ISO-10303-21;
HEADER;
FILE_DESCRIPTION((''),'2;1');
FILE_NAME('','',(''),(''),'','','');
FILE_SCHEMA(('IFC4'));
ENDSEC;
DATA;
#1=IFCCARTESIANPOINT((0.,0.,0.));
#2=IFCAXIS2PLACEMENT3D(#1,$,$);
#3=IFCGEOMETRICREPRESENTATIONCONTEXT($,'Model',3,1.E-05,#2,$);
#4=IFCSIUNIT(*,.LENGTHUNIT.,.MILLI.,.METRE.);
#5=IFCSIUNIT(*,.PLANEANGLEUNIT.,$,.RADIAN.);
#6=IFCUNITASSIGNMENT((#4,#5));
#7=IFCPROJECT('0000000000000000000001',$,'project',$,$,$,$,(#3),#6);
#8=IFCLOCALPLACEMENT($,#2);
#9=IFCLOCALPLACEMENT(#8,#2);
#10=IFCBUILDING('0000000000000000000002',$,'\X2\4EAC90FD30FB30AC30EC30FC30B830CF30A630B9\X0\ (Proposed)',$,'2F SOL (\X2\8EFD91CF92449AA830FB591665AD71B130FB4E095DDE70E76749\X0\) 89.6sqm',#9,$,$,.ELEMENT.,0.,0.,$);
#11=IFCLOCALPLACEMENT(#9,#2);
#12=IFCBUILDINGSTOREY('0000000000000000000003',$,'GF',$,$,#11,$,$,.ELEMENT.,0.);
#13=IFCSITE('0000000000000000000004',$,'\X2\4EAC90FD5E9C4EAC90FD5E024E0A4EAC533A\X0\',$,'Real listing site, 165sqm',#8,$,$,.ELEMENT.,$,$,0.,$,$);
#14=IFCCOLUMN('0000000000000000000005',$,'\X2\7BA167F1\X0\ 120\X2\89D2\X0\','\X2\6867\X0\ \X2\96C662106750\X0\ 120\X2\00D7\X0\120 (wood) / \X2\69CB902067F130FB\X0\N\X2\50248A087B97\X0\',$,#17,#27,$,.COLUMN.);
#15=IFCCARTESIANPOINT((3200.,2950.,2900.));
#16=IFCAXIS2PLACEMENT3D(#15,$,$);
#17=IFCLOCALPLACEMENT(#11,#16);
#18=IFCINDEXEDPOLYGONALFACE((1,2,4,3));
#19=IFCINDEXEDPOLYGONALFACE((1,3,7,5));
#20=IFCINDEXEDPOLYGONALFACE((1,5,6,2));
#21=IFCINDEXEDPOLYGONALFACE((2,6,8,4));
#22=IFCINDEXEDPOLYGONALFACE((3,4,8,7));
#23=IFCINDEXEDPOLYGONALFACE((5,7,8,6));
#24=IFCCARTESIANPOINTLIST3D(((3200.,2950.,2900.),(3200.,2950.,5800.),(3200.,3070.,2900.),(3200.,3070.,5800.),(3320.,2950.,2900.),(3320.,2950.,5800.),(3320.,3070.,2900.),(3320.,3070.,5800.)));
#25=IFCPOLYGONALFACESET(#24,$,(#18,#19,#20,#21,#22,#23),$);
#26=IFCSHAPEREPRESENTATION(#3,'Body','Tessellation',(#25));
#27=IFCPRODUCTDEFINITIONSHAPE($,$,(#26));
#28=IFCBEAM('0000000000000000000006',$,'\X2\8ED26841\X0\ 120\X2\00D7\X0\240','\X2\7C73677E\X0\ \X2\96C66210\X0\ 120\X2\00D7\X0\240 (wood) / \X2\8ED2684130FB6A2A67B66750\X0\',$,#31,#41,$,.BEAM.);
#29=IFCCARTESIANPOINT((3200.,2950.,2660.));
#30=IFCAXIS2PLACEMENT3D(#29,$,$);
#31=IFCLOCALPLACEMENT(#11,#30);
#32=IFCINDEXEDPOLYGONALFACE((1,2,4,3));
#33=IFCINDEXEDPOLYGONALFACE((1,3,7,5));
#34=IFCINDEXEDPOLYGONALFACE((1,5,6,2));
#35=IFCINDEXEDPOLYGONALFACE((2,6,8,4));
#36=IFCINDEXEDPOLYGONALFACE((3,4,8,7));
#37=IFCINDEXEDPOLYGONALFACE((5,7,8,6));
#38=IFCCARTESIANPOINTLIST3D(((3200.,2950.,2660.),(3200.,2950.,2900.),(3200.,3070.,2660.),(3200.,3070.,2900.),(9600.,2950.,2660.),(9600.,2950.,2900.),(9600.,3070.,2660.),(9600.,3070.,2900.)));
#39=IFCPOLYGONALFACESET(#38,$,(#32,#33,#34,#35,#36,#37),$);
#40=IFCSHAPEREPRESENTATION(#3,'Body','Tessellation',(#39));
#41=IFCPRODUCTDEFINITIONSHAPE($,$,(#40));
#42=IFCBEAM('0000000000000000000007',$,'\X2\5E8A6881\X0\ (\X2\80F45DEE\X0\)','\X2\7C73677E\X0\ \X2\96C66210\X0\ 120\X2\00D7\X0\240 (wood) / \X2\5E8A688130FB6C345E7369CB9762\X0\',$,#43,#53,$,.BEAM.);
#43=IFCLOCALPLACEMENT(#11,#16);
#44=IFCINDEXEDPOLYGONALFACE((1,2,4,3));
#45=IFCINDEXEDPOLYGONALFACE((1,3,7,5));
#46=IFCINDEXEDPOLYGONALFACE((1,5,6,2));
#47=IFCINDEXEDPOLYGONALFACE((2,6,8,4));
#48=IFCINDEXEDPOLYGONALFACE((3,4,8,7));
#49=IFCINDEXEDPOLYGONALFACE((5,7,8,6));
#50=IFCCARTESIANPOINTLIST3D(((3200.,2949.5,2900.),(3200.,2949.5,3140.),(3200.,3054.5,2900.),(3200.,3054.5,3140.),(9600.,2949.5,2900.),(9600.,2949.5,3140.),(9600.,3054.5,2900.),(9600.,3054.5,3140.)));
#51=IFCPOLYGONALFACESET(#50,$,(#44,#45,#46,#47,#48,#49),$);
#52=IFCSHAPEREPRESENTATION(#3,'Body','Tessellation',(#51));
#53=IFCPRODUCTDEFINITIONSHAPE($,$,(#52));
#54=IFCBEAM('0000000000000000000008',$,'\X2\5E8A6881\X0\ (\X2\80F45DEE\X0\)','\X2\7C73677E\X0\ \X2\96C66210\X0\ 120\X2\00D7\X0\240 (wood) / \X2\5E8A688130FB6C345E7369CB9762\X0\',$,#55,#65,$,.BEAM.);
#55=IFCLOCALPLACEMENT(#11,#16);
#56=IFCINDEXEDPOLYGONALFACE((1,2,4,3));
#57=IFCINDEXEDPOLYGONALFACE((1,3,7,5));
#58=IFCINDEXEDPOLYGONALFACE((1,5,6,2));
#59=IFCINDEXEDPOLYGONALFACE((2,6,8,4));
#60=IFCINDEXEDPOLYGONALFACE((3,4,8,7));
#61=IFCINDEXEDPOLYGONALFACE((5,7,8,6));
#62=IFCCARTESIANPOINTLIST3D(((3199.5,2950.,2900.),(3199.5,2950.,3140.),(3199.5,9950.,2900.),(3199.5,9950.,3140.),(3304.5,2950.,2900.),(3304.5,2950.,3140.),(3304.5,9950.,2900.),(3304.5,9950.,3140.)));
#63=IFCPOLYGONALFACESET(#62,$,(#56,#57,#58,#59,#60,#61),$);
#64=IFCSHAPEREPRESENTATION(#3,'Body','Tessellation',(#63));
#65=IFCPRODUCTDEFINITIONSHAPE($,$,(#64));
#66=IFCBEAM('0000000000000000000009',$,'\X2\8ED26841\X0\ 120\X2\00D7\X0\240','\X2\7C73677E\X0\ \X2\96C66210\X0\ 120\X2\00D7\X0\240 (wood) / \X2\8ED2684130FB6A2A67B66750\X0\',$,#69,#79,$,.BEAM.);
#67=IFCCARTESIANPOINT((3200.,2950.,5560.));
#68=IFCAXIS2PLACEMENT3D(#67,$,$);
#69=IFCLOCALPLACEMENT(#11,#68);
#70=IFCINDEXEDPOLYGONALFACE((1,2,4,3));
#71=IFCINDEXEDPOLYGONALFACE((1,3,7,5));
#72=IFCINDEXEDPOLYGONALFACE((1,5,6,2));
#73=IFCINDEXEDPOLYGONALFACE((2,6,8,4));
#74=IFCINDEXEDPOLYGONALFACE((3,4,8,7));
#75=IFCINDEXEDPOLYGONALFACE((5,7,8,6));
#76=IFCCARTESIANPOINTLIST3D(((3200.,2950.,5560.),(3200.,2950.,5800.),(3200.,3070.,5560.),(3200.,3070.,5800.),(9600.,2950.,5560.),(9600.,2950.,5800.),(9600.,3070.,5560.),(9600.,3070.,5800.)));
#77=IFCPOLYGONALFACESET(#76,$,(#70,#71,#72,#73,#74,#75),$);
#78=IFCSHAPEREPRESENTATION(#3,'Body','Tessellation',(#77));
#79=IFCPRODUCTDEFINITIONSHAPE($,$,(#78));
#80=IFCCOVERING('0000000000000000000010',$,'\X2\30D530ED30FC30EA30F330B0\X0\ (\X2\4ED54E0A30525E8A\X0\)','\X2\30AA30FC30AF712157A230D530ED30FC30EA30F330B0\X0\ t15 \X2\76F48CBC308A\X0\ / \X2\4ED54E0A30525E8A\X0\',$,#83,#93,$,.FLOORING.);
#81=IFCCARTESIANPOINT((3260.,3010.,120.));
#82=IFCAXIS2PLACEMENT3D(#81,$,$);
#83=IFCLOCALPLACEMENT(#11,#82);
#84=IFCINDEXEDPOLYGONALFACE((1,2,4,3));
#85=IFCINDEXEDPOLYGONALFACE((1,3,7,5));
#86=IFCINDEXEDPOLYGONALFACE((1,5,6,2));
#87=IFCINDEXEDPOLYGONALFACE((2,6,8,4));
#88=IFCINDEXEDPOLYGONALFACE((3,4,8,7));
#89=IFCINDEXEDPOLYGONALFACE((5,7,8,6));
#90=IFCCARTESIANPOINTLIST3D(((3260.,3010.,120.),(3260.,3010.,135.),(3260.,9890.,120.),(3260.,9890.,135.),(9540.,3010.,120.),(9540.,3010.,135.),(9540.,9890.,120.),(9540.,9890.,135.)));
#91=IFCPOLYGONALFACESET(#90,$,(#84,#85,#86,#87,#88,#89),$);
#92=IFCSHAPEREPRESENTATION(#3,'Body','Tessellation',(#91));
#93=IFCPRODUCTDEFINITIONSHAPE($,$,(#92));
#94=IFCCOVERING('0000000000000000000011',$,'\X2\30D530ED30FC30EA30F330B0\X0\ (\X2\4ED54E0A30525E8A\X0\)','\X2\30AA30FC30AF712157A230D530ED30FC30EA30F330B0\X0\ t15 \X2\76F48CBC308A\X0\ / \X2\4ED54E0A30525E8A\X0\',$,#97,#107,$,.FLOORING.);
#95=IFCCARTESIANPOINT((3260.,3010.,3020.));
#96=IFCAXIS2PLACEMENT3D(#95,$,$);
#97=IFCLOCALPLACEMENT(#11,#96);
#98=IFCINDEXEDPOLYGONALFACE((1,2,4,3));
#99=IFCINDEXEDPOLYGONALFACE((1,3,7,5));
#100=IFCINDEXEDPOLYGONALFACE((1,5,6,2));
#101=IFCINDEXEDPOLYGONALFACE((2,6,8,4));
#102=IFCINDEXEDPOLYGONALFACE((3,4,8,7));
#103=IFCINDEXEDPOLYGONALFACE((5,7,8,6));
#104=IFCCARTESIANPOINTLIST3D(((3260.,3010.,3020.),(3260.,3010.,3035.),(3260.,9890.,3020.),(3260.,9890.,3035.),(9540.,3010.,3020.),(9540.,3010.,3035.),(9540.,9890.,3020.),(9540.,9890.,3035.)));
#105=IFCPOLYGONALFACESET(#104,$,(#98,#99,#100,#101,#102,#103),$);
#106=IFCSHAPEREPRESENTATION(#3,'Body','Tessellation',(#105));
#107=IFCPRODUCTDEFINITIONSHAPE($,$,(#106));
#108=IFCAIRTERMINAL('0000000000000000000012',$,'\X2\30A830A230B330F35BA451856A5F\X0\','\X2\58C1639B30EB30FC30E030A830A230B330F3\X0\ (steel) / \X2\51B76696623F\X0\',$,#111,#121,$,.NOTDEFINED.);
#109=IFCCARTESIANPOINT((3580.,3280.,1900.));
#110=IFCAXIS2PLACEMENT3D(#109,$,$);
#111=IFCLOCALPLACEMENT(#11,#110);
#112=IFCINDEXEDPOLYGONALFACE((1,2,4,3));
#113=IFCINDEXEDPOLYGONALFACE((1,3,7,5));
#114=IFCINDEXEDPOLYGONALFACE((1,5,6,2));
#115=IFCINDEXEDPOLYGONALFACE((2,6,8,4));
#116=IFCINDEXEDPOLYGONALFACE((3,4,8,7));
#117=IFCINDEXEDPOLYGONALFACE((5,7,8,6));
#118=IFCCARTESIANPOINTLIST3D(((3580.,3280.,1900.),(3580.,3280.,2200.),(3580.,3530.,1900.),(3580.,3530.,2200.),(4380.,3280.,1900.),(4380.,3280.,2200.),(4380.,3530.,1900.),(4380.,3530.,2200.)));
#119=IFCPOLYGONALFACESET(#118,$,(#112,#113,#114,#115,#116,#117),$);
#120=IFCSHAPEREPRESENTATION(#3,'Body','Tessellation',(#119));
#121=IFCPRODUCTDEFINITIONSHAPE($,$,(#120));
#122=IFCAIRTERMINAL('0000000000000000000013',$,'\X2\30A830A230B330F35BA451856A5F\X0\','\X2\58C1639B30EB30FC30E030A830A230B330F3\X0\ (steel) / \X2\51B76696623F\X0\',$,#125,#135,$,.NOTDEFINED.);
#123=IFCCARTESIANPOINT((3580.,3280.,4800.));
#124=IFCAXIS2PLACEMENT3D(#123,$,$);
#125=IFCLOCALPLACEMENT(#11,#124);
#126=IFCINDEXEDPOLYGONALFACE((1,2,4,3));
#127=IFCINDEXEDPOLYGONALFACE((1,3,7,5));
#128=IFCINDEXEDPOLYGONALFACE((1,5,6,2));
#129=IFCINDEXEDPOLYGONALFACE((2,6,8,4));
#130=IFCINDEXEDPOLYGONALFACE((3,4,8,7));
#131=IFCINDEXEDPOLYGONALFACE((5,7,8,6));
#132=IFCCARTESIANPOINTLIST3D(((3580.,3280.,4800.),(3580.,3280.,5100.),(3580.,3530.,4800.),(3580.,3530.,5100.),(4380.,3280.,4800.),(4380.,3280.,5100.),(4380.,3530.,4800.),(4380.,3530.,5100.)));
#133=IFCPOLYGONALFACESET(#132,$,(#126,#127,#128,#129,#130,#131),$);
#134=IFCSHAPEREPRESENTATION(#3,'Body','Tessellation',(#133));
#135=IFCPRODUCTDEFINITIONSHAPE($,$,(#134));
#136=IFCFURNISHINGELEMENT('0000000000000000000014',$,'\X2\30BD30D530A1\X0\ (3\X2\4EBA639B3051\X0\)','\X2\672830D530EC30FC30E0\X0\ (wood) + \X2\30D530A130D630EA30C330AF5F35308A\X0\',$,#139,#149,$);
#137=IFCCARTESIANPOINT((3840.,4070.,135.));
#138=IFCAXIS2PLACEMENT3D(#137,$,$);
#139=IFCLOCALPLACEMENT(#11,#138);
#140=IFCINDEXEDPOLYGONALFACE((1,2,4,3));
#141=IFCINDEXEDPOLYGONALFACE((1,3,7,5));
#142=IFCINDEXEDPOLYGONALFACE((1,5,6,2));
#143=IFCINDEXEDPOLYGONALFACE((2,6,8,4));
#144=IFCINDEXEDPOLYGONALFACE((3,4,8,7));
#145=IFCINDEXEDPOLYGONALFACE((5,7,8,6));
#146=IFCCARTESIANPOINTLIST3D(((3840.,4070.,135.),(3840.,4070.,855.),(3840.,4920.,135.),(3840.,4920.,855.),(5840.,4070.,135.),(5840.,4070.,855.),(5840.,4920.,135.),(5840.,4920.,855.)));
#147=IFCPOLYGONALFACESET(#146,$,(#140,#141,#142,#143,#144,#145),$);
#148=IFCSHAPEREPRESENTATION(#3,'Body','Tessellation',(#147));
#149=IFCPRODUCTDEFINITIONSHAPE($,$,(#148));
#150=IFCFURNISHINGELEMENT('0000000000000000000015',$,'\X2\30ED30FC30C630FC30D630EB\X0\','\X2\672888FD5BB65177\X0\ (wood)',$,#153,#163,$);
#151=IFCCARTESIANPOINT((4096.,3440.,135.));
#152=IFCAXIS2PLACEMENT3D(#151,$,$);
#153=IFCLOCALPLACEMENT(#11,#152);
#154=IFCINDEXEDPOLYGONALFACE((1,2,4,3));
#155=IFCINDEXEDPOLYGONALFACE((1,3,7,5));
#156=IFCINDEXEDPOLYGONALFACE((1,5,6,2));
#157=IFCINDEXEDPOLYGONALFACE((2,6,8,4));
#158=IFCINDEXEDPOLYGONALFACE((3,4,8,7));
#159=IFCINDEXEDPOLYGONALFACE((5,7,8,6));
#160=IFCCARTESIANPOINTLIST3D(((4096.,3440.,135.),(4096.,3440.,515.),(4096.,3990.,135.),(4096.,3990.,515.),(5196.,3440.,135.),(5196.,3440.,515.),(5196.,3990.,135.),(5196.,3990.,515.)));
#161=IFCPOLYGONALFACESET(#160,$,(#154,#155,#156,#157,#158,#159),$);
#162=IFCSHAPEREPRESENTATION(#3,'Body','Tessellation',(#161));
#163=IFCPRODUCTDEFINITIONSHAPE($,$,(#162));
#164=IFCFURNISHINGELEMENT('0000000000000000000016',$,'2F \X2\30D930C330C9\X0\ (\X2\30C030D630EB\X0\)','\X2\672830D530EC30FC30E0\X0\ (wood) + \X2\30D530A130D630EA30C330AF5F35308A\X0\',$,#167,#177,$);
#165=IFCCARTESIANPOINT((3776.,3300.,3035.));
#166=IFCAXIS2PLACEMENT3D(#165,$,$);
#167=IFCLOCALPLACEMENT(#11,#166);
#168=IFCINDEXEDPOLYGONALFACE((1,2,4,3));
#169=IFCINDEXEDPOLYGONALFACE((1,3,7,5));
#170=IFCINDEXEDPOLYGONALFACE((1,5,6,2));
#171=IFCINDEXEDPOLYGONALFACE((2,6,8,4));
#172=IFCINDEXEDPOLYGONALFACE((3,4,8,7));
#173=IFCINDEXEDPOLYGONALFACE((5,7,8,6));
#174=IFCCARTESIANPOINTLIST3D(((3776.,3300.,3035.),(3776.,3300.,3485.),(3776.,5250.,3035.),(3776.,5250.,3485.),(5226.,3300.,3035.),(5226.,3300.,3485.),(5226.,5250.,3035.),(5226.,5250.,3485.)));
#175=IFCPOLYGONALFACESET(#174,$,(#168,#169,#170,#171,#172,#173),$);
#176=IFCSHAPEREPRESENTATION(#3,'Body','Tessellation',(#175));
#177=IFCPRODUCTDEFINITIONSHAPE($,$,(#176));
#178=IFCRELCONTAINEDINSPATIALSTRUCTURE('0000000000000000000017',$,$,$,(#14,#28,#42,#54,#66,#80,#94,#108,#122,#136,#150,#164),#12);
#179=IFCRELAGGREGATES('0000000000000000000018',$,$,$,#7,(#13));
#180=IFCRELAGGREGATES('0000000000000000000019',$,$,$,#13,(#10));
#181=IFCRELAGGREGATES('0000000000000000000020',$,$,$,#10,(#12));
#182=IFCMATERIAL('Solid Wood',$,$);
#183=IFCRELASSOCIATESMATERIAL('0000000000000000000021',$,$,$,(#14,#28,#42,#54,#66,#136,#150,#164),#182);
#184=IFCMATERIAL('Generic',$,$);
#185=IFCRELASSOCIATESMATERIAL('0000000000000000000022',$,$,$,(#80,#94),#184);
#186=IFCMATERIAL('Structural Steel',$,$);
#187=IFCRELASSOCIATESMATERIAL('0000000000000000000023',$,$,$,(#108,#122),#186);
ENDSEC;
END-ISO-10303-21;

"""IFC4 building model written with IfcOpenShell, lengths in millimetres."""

from ifc_helpers import new_model, si_unit, frame, frame_2d, origin, place, context, project, spatial, rectangle, extrude, material, element, save


model = new_model("IFC4")

# Units and contexts
model_context = context("Model", 3, precision=1e-05, world=origin())
ifc_project = project(units=[si_unit("LENGTHUNIT", "METRE", prefix="MILLI"), si_unit("PLANEANGLEUNIT", "RADIAN")], contexts=[model_context])

# Site, building, storey
site_placement = place(None, origin())
site = spatial("IfcSite", under=ifc_project, at=site_placement, Name="京都府京都市上京区", ObjectType="Real listing site, 165sqm", CompositionType="ELEMENT", RefElevation=0.0)
building_placement = place(site_placement, origin())
building = spatial("IfcBuilding", under=site, at=building_placement, Name="京都・ガレージハウス (Proposed)", ObjectType="2F SOL (軽量鉄骨・外断熱・三州烧杉) 89.6sqm", CompositionType="ELEMENT", ElevationOfRefHeight=0.0, ElevationOfTerrain=0.0)
storey_placement = place(building_placement, origin())
storey = spatial("IfcBuildingStorey", under=building, at=storey_placement, Name="GF", CompositionType="ELEMENT", Elevation=0.0)

# Column
ifc_material_1 = material(Name="Solid Wood")
column_1_placement = place(storey_placement, frame((3200.0, 2950.0, 2900.0)))
element("IfcColumn", 1, at=column_1_placement, inside=storey, material=ifc_material_1, Name="管柱 120角", Description="桧 集成材 120×120 (wood) / 構造柱・N値計算", PredefinedType="COLUMN", context=model_context, shape_type="SweptSolid", body=[
    extrude(rectangle(XDim=120.0, YDim=120.0, at=frame_2d((60.0, 60.0))), frame((3200.0, 2950.0, 2900.0)), (0.0, 0.0, 1.0), 2900.0),
])

# Beams
beam_1_placement = place(storey_placement, frame((3200.0, 2950.0, 2660.0)))
element("IfcBeam", 2, at=beam_1_placement, inside=storey, material=ifc_material_1, Name="軒桁 120×240", Description="米松 集成 120×240 (wood) / 軒桁・横架材", PredefinedType="BEAM", context=model_context, shape_type="SweptSolid", body=[
    extrude(rectangle(XDim=6400.0, YDim=120.0, at=frame_2d((3200.0, 60.0))), frame((3200.0, 2950.0, 2660.0)), (0.0, 0.0, 1.0), 240.0),
])
beam_2_placement = place(storey_placement, frame((3200.0, 2950.0, 2900.0)))
element("IfcBeam", 3, at=beam_2_placement, inside=storey, material=ifc_material_1, Name="床梁 (胴差)", Description="米松 集成 120×240 (wood) / 床梁・水平構面", PredefinedType="BEAM", context=model_context, shape_type="SweptSolid", body=[
    extrude(rectangle(XDim=6400.0, YDim=105.0, at=frame_2d((3200.0, 52.0))), frame((3200.0, 2950.0, 2900.0)), (0.0, 0.0, 1.0), 240.0),
])
beam_3_placement = place(storey_placement, frame((3200.0, 2950.0, 2900.0)))
element("IfcBeam", 4, at=beam_3_placement, inside=storey, material=ifc_material_1, Name="床梁 (胴差)", Description="米松 集成 120×240 (wood) / 床梁・水平構面", PredefinedType="BEAM", context=model_context, shape_type="SweptSolid", body=[
    extrude(rectangle(XDim=105.0, YDim=7000.0, at=frame_2d((52.0, 3500.0))), frame((3200.0, 2950.0, 2900.0)), (0.0, 0.0, 1.0), 240.0),
])
beam_4_placement = place(storey_placement, frame((3200.0, 2950.0, 5560.0)))
element("IfcBeam", 5, at=beam_4_placement, inside=storey, material=ifc_material_1, Name="軒桁 120×240", Description="米松 集成 120×240 (wood) / 軒桁・横架材", PredefinedType="BEAM", context=model_context, shape_type="SweptSolid", body=[
    extrude(rectangle(XDim=6400.0, YDim=120.0, at=frame_2d((3200.0, 60.0))), frame((3200.0, 2950.0, 5560.0)), (0.0, 0.0, 1.0), 240.0),
])

# Coverings
ifc_material_2 = material(Name="Generic")
covering_1_placement = place(storey_placement, frame((3260.0, 3010.0, 120.0)))
element("IfcCovering", 6, at=covering_1_placement, inside=storey, material=ifc_material_2, Name="フローリング (仕上げ床)", Description="オーク無垢フローリング t15 直貼り / 仕上げ床", PredefinedType="FLOORING", context=model_context, shape_type="SweptSolid", body=[
    extrude(rectangle(XDim=6280.0, YDim=6880.0, at=frame_2d((3140.0, 3440.0))), frame((3260.0, 3010.0, 120.0)), (0.0, 0.0, 1.0), 15.0),
])
covering_2_placement = place(storey_placement, frame((3260.0, 3010.0, 3020.0)))
element("IfcCovering", 7, at=covering_2_placement, inside=storey, material=ifc_material_2, Name="フローリング (仕上げ床)", Description="オーク無垢フローリング t15 直貼り / 仕上げ床", PredefinedType="FLOORING", context=model_context, shape_type="SweptSolid", body=[
    extrude(rectangle(XDim=6280.0, YDim=6880.0, at=frame_2d((3140.0, 3440.0))), frame((3260.0, 3010.0, 3020.0)), (0.0, 0.0, 1.0), 15.0),
])

# Air terminals
ifc_material_3 = material(Name="Structural Steel")
air_terminal_1_placement = place(storey_placement, frame((3580.0, 3280.0, 1900.0)))
element("IfcAirTerminal", 8, at=air_terminal_1_placement, inside=storey, material=ifc_material_3, Name="エアコン室内機", Description="壁掛ルームエアコン (steel) / 冷暖房", PredefinedType="NOTDEFINED", context=model_context, shape_type="SweptSolid", body=[
    extrude(rectangle(XDim=800.0, YDim=250.0, at=frame_2d((400.0, 125.0))), frame((3580.0, 3280.0, 1900.0)), (0.0, 0.0, 1.0), 300.0),
])
air_terminal_2_placement = place(storey_placement, frame((3580.0, 3280.0, 4800.0)))
element("IfcAirTerminal", 9, at=air_terminal_2_placement, inside=storey, material=ifc_material_3, Name="エアコン室内機", Description="壁掛ルームエアコン (steel) / 冷暖房", PredefinedType="NOTDEFINED", context=model_context, shape_type="SweptSolid", body=[
    extrude(rectangle(XDim=800.0, YDim=250.0, at=frame_2d((400.0, 125.0))), frame((3580.0, 3280.0, 4800.0)), (0.0, 0.0, 1.0), 300.0),
])

# Furnishing elements
furnishing_1_placement = place(storey_placement, frame((3840.0, 4070.0, 135.0)))
element("IfcFurnishingElement", 10, at=furnishing_1_placement, inside=storey, material=ifc_material_1, Name="ソファ (3人掛け)", Description="木フレーム (wood) + ファブリック張り", context=model_context, shape_type="SweptSolid", body=[
    extrude(rectangle(XDim=2000.0, YDim=850.0, at=frame_2d((1000.0, 425.0))), frame((3840.0, 4070.0, 135.0)), (0.0, 0.0, 1.0), 720.0),
])
furnishing_2_placement = place(storey_placement, frame((4096.0, 3440.0, 135.0)))
element("IfcFurnishingElement", 11, at=furnishing_2_placement, inside=storey, material=ifc_material_1, Name="ローテーブル", Description="木製家具 (wood)", context=model_context, shape_type="SweptSolid", body=[
    extrude(rectangle(XDim=1100.0, YDim=550.0, at=frame_2d((550.0, 275.0))), frame((4096.0, 3440.0, 135.0)), (0.0, 0.0, 1.0), 380.0),
])
furnishing_3_placement = place(storey_placement, frame((3776.0, 3300.0, 3035.0)))
element("IfcFurnishingElement", 12, at=furnishing_3_placement, inside=storey, material=ifc_material_1, Name="2F ベッド (ダブル)", Description="木フレーム (wood) + ファブリック張り", context=model_context, shape_type="SweptSolid", body=[
    extrude(rectangle(XDim=1450.0, YDim=1950.0, at=frame_2d((725.0, 975.0))), frame((3776.0, 3300.0, 3035.0)), (0.0, 0.0, 1.0), 450.0),
])

save(model, "model.ifc")
